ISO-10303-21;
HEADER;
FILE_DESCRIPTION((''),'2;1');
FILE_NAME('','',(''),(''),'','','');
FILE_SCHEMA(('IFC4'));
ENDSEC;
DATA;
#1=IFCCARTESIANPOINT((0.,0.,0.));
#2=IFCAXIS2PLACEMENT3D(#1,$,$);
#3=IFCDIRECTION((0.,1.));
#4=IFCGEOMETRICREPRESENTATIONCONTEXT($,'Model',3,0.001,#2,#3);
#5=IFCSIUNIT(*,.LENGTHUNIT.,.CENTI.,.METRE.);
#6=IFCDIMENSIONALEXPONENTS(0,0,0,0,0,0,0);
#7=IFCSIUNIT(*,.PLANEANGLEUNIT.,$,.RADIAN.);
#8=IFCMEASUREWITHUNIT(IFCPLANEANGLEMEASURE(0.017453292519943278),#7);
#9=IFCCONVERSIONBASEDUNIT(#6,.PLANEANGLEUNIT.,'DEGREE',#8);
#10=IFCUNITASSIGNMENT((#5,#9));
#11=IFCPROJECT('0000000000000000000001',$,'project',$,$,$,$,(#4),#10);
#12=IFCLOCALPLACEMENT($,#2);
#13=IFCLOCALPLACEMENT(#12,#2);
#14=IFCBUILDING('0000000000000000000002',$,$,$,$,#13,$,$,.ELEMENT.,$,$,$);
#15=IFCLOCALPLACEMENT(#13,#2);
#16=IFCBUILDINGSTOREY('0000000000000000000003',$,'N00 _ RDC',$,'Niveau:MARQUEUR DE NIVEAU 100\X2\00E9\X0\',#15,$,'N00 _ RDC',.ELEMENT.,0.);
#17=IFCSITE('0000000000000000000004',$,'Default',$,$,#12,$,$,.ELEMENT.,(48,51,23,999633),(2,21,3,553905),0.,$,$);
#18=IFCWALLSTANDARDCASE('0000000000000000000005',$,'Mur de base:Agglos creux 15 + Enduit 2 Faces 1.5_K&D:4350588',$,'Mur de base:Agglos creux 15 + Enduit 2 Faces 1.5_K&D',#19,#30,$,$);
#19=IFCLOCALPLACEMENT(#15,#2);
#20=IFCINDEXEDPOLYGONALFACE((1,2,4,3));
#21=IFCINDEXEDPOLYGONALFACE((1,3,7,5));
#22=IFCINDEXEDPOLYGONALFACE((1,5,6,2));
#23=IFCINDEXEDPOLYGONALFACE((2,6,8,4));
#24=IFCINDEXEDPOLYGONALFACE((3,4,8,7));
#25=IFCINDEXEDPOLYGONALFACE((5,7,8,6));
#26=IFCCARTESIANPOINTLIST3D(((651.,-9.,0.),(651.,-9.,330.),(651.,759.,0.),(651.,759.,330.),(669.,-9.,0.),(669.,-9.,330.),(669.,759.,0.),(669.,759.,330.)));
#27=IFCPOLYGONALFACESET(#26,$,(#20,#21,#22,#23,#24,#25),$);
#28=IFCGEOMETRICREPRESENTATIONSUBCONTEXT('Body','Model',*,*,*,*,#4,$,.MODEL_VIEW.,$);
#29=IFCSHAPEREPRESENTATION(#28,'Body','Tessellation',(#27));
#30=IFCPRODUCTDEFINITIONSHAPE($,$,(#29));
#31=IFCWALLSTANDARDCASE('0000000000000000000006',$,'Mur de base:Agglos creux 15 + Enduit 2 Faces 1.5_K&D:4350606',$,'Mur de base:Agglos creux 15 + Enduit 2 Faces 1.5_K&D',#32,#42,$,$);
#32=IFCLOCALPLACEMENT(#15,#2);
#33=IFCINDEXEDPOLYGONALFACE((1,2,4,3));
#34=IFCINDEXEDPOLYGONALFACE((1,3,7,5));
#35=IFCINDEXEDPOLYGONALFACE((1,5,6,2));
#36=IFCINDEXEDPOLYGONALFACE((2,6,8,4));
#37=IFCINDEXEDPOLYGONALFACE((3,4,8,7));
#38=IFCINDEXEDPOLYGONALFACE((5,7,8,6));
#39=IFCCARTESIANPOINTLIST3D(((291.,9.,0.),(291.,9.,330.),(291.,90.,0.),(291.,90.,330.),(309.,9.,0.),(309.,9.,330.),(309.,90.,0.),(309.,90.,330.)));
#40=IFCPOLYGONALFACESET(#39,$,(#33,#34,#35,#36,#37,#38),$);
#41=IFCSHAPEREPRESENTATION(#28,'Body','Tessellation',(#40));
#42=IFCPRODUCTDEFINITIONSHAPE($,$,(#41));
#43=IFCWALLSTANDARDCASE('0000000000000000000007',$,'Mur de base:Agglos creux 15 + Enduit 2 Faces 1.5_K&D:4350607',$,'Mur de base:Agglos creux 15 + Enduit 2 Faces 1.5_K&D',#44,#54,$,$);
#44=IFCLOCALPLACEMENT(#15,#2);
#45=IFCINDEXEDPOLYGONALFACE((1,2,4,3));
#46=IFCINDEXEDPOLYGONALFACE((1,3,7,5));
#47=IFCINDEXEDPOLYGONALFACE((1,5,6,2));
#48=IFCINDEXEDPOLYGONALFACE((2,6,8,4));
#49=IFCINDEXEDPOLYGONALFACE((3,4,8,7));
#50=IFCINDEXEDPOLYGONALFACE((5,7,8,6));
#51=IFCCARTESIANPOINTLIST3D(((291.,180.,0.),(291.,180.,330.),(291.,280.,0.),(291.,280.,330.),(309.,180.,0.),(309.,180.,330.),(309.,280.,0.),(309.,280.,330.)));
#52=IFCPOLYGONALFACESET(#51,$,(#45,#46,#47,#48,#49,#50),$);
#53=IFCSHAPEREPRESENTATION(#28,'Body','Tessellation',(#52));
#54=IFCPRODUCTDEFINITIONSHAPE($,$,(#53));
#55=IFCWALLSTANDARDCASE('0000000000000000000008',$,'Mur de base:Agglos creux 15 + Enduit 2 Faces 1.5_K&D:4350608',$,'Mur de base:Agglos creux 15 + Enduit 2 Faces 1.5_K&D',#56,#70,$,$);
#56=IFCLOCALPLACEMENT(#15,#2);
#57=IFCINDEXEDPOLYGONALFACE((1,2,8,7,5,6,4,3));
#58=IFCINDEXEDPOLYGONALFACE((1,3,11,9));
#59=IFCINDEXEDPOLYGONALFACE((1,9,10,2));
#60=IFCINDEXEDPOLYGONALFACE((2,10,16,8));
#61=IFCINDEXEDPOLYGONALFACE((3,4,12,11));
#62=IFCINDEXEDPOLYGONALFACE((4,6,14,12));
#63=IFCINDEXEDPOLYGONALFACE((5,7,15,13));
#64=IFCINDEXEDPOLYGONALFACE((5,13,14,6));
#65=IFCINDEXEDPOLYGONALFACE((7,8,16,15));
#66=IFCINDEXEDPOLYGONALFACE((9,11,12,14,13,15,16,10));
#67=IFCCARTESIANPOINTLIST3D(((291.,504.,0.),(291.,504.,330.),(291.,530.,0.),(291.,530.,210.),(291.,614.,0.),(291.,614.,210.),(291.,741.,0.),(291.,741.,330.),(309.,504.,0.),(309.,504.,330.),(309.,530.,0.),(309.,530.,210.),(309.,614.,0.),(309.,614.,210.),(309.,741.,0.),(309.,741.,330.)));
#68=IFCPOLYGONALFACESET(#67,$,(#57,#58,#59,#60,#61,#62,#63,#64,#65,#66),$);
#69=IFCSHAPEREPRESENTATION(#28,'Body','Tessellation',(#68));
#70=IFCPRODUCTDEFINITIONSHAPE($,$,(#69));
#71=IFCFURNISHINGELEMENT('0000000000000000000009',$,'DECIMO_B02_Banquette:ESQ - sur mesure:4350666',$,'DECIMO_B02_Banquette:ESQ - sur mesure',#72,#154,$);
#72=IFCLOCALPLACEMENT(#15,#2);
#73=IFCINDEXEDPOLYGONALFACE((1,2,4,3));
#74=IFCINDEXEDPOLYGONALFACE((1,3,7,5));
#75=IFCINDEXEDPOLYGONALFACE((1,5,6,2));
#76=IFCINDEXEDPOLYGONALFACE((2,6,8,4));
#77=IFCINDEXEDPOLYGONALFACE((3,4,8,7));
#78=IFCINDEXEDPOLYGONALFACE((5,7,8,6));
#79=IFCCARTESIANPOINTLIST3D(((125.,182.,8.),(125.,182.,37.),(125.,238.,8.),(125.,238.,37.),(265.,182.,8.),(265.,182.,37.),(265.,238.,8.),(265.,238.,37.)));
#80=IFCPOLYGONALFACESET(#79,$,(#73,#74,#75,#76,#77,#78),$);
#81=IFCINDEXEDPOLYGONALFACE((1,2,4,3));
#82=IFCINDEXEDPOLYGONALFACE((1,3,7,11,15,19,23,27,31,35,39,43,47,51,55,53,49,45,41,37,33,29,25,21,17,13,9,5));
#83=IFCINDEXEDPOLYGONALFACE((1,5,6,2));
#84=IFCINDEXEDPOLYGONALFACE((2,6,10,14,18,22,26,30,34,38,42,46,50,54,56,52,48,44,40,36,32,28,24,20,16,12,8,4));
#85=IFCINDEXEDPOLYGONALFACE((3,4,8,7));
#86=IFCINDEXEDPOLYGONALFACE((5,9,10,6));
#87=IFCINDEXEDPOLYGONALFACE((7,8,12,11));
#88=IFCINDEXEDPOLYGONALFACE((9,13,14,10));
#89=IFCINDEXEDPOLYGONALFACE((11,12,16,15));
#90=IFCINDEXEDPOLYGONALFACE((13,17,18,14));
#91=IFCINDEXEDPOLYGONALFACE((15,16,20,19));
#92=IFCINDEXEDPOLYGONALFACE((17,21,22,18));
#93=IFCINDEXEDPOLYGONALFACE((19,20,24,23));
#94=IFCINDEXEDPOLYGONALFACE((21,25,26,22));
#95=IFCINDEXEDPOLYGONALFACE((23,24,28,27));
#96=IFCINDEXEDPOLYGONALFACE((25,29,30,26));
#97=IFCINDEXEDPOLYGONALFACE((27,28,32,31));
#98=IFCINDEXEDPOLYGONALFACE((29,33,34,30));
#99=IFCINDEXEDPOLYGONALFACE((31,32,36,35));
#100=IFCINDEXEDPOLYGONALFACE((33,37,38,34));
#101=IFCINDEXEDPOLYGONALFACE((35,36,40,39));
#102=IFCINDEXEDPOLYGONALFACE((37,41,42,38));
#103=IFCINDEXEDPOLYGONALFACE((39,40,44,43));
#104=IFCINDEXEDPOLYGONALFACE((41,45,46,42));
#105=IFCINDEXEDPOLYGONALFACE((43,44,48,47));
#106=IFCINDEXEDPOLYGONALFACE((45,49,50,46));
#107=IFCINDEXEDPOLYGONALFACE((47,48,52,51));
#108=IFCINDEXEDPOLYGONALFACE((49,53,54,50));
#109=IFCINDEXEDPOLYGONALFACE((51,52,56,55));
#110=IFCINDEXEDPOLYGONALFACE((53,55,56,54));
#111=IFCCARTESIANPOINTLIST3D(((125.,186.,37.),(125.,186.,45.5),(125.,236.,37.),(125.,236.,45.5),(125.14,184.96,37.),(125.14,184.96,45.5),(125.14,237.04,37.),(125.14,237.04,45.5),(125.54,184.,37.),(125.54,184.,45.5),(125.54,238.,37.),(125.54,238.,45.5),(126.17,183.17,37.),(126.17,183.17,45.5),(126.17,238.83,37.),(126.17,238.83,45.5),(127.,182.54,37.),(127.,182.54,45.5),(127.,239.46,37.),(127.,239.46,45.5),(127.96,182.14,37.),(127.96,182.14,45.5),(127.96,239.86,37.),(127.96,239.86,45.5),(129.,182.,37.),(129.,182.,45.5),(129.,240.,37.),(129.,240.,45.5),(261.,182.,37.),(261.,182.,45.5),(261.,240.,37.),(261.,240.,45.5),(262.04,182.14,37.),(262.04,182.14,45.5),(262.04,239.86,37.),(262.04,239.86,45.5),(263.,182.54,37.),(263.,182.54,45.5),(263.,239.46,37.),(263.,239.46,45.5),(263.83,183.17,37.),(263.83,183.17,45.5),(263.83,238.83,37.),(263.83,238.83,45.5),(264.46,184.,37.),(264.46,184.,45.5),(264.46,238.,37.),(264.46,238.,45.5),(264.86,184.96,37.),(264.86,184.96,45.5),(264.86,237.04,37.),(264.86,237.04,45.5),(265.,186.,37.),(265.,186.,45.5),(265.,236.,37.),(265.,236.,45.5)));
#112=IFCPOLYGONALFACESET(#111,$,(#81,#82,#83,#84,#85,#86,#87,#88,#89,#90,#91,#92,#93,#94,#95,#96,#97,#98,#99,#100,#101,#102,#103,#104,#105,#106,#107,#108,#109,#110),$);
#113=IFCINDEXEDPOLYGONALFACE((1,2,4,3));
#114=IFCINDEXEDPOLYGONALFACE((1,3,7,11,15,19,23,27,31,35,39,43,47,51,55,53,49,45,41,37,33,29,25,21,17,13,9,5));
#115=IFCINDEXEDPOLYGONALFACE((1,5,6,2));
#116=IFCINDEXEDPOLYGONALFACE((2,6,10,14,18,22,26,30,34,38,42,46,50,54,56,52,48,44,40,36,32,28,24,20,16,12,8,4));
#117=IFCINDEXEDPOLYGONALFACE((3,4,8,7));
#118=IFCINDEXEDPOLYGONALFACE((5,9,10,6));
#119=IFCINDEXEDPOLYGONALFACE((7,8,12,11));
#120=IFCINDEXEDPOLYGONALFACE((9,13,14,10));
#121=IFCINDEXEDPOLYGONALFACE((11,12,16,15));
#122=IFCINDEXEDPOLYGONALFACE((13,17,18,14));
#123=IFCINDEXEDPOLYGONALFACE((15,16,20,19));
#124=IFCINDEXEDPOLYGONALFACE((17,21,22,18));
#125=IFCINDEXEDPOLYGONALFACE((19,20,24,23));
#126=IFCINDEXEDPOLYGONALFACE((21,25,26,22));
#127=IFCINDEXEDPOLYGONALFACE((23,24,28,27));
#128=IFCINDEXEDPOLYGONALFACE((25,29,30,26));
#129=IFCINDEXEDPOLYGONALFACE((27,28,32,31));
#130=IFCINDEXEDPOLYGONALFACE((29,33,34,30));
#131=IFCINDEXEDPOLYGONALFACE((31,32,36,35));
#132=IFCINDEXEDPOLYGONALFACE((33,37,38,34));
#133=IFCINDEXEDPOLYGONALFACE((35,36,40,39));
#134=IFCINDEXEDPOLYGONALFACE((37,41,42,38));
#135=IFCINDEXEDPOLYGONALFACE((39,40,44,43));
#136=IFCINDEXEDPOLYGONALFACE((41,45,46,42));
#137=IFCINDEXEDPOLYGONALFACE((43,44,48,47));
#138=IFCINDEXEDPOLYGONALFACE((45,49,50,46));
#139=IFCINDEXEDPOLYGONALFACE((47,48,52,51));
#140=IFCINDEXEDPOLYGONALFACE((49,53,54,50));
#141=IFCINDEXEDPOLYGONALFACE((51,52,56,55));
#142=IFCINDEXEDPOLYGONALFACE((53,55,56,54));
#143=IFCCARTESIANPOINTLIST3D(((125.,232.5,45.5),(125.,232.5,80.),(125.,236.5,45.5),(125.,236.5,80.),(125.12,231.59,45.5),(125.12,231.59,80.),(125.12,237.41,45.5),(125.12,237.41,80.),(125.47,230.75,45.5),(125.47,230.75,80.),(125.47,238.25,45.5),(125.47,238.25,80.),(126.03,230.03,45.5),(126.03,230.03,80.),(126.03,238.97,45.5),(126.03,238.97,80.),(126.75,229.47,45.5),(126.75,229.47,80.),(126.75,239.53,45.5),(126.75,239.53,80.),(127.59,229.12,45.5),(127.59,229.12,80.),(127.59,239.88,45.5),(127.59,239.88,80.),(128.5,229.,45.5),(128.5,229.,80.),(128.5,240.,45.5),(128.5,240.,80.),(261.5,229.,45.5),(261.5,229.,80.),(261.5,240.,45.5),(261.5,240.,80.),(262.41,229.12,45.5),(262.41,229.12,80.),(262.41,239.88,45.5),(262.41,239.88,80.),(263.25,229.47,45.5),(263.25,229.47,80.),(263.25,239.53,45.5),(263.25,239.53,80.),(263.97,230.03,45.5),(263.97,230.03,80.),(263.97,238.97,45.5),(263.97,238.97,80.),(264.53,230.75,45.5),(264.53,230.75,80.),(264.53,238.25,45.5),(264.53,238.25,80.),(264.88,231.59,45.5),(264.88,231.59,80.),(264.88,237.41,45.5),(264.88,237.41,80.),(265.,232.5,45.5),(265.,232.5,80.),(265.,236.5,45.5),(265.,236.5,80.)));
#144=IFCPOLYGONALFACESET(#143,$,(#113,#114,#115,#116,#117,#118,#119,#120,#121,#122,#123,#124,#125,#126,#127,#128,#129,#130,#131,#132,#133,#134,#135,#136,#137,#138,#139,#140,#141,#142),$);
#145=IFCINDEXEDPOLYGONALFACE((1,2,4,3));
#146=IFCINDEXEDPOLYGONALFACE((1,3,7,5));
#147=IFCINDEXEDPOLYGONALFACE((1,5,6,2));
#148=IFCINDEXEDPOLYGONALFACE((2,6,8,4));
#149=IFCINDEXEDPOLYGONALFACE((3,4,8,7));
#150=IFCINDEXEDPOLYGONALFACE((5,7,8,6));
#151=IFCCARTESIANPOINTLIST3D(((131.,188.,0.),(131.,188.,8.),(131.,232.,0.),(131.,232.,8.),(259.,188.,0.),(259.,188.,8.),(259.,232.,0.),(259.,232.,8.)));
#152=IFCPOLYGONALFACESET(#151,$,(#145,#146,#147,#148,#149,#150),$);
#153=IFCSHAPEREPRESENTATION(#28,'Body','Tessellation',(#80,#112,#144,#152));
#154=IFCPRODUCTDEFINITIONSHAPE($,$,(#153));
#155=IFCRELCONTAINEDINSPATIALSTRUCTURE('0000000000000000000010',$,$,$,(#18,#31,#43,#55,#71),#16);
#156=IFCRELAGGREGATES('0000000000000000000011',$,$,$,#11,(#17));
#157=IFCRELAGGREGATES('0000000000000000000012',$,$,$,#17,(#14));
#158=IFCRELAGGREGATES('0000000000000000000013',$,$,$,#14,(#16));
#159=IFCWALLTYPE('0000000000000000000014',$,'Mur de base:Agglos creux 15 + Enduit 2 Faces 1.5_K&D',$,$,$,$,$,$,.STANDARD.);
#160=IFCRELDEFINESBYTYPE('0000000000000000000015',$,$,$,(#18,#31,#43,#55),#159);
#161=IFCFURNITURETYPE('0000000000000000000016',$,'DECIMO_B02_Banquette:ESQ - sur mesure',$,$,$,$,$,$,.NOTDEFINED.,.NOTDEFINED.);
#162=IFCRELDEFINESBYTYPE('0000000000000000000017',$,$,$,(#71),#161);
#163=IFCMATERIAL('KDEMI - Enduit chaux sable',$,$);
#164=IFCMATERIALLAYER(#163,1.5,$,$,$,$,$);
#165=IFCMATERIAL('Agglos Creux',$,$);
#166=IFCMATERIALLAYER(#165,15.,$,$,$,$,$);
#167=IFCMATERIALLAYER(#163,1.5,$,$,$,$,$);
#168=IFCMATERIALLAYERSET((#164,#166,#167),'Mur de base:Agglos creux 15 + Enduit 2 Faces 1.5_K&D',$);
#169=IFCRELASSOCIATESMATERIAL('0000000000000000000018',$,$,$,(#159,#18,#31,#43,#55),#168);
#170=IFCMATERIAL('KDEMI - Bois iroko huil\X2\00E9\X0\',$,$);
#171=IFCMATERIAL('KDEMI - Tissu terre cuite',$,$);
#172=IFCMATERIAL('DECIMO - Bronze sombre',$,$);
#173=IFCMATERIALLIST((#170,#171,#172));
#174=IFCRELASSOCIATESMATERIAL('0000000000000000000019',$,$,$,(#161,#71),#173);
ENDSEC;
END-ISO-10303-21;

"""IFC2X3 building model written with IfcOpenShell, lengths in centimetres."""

from ifc_helpers import new_model, entity, si_unit, converted_unit, direction, frame, frame_2d, origin, origin_2d_with_axis, place, context, subcontext, project, spatial, polyline, circle_curve, parameter, trimmed, segment, composite_curve, rectangle, outline, extrude, source, transform, mapped, material, material_list, layer, layer_set, layer_usage, type_object, type_shapes, element, save


model = new_model("IFC2X3")

# Units and contexts
model_context = context("Model", 3, precision=0.001, world=origin(), true_north=direction((0.0, 1.0)))
body_context = subcontext(model_context, "Body", "Model", "MODEL_VIEW")
ifc_project = project(units=[si_unit("LENGTHUNIT", "METRE", prefix="CENTI"), converted_unit("PLANEANGLEUNIT", "DEGREE", entity("IfcPlaneAngleMeasure", 0.017453292519943278), si_unit("PLANEANGLEUNIT", "RADIAN"), dimensions=[0, 0, 0, 0, 0, 0, 0])], contexts=[model_context])

# Site, building, storey
site_placement = place(None, origin())
site = spatial("IfcSite", under=ifc_project, at=site_placement, Name="Default", CompositionType="ELEMENT", RefLatitude=(48, 51, 23, 999633), RefLongitude=(2, 21, 3, 553905), RefElevation=0.0)
building_placement = place(site_placement, origin())
building = spatial("IfcBuilding", under=site, at=building_placement, CompositionType="ELEMENT")
storey_placement = place(building_placement, origin())
storey = spatial("IfcBuildingStorey", under=building, at=storey_placement, Name="N00 _ RDC", ObjectType="Niveau:MARQUEUR DE NIVEAU 100é", LongName="N00 _ RDC", CompositionType="ELEMENT", Elevation=0.0)

# Walls
ifc_material_1 = material(Name="KDEMI - Enduit chaux sable")
ifc_layer_1 = layer(ifc_material_1, 1.5)
ifc_material_2 = material(Name="Agglos Creux")
ifc_layer_2 = layer(ifc_material_2, 15.0)
ifc_layer_3 = layer(ifc_material_1, 1.5)
ifc_layer_set = layer_set([ifc_layer_1, ifc_layer_2, ifc_layer_3], Name="Mur de base:Agglos creux 15 + Enduit 2 Faces 1.5_K&D")
ifc_layer_usage_1 = layer_usage(ifc_layer_set, "AXIS2", "NEGATIVE", 9.0)
wall_type = type_object("IfcWallType", Name="Mur de base:Agglos creux 15 + Enduit 2 Faces 1.5_K&D", PredefinedType="STANDARD", material=ifc_layer_set)
wall_1_placement = place(storey_placement, frame((660.0, -9.0, 0.0), z_axis=(0.0, 0.0, 1.0), x_axis=(0.0, 1.0, 0.0)))
element("IfcWallStandardCase", 1, at=wall_1_placement, inside=storey, type_object=wall_type, material=ifc_layer_usage_1, Name="Mur de base:Agglos creux 15 + Enduit 2 Faces 1.5_K&D:4350588", ObjectType="Mur de base:Agglos creux 15 + Enduit 2 Faces 1.5_K&D", context=body_context, shape_type="SweptSolid", body=[
    extrude(rectangle(XDim=768.0, YDim=18.0, at=frame_2d((384.0, 0.0), x_axis=(-1.0, 0.0))), origin(), (0.0, 0.0, 1.0), 330.0),
])
ifc_layer_usage_2 = layer_usage(ifc_layer_set, "AXIS2", "NEGATIVE", 9.0)
wall_2_placement = place(storey_placement, frame((300.0, 9.0, 0.0), z_axis=(0.0, 0.0, 1.0), x_axis=(0.0, 1.0, 0.0)))
element("IfcWallStandardCase", 2, at=wall_2_placement, inside=storey, type_object=wall_type, material=ifc_layer_usage_2, Name="Mur de base:Agglos creux 15 + Enduit 2 Faces 1.5_K&D:4350606", ObjectType="Mur de base:Agglos creux 15 + Enduit 2 Faces 1.5_K&D", context=body_context, shape_type="SweptSolid", body=[
    extrude(rectangle(XDim=81.0, YDim=18.0, at=frame_2d((40.5, 0.0), x_axis=(-1.0, 0.0))), origin(), (0.0, 0.0, 1.0), 330.0),
])
ifc_layer_usage_3 = layer_usage(ifc_layer_set, "AXIS2", "NEGATIVE", 9.0)
wall_3_placement = place(storey_placement, frame((300.0, 180.0, 0.0), z_axis=(0.0, 0.0, 1.0), x_axis=(0.0, 1.0, 0.0)))
element("IfcWallStandardCase", 3, at=wall_3_placement, inside=storey, type_object=wall_type, material=ifc_layer_usage_3, Name="Mur de base:Agglos creux 15 + Enduit 2 Faces 1.5_K&D:4350607", ObjectType="Mur de base:Agglos creux 15 + Enduit 2 Faces 1.5_K&D", context=body_context, shape_type="SweptSolid", body=[
    extrude(rectangle(XDim=100.0, YDim=18.0, at=frame_2d((50.0, 0.0), x_axis=(-1.0, 0.0))), origin(), (0.0, 0.0, 1.0), 330.0),
])

# Wall, opening
ifc_layer_usage_4 = layer_usage(ifc_layer_set, "AXIS2", "POSITIVE", -9.0)
wall_4_placement = place(storey_placement, frame((300.0, 504.0, 0.0), z_axis=(0.0, 0.0, 1.0), x_axis=(0.0, 1.0, 0.0)))
wall_4 = element("IfcWallStandardCase", 4, at=wall_4_placement, inside=storey, type_object=wall_type, material=ifc_layer_usage_4, Name="Mur de base:Agglos creux 15 + Enduit 2 Faces 1.5_K&D:4350608", ObjectType="Mur de base:Agglos creux 15 + Enduit 2 Faces 1.5_K&D", context=body_context, shape_type="SweptSolid", body=[
    extrude(rectangle(XDim=237.0, YDim=18.0, at=frame_2d((118.5, 0.0), x_axis=(1.0, 0.0))), origin(), (0.0, 0.0, 1.0), 330.0),
])
opening_placement = place(wall_4_placement, frame((-504.0, 300.0, 0.0), z_axis=(0.0, 0.0, 1.0), x_axis=(0.0, -1.0, 0.0)))
element("IfcOpeningElement", 5, at=opening_placement, inside=storey, cuts=wall_4, context=body_context, shape_type="SweptSolid", body=[
    extrude(rectangle(XDim=22.0, YDim=84.0, at=frame_2d((300.0, 572.0))), origin(), (0.0, 0.0, 1.0), 210.0),
])

# Furnishing element
ifc_material_3 = material(Name="DECIMO - Bronze sombre")
ifc_material_4 = material(Name="KDEMI - Bois iroko huilé")
ifc_material_5 = material(Name="KDEMI - Tissu terre cuite")
ifc_material_list_1 = material_list([ifc_material_4, ifc_material_5, ifc_material_3])
furniture_type_1 = type_object("IfcFurnitureType", Name="DECIMO_B02_Banquette:ESQ - sur mesure", AssemblyPlace="NOTDEFINED", material=ifc_material_list_1)
shared_shape_1 = source(origin(), body_context, "Body", "SweptSolid", [
    extrude(rectangle(XDim=140.0, YDim=56.0, at=origin_2d_with_axis()), frame((70.0, 28.0, 8.0)), (0.0, 0.0, 1.0), 29.0),
    extrude(outline(composite_curve([segment(polyline([(-66.0, -29.0), (66.0, -29.0)]), True, "CONTINUOUS"), segment(trimmed(circle_curve(frame_2d((66.0, -25.0), x_axis=(1.0, 0.0)), 4.0), [parameter(270.0)], [parameter(0.0)], True, "PARAMETER"), True, "CONTINUOUS"), segment(polyline([(70.0, -25.0), (70.0, 25.0)]), True, "CONTINUOUS"), segment(trimmed(circle_curve(frame_2d((66.0, 25.0), x_axis=(1.0, 0.0)), 4.0), [parameter(0.0)], [parameter(90.0)], True, "PARAMETER"), True, "CONTINUOUS"), segment(polyline([(66.0, 29.0), (-66.0, 29.0)]), True, "CONTINUOUS"), segment(trimmed(circle_curve(frame_2d((-66.0, 25.0), x_axis=(1.0, 0.0)), 4.0), [parameter(90.0)], [parameter(180.0)], True, "PARAMETER"), True, "CONTINUOUS"), segment(polyline([(-70.0, 25.0), (-70.0, -25.0)]), True, "CONTINUOUS"), segment(trimmed(circle_curve(frame_2d((-66.0, -25.0), x_axis=(1.0, 0.0)), 4.0), [parameter(180.0)], [parameter(270.0)], True, "PARAMETER"), True, "CONTINUOUS")], self_intersect=False)), frame((70.0, 29.0, 37.0)), (0.0, 0.0, 1.0), 8.5),
    extrude(outline(composite_curve([segment(polyline([(-66.5, -5.5), (66.5, -5.5)]), True, "CONTINUOUS"), segment(trimmed(circle_curve(frame_2d((66.5, -2.0), x_axis=(1.0, 0.0)), 3.5), [parameter(270.0)], [parameter(0.0)], True, "PARAMETER"), True, "CONTINUOUS"), segment(polyline([(70.0, -2.0), (70.0, 2.0)]), True, "CONTINUOUS"), segment(trimmed(circle_curve(frame_2d((66.5, 2.0), x_axis=(1.0, 0.0)), 3.5), [parameter(0.0)], [parameter(90.0)], True, "PARAMETER"), True, "CONTINUOUS"), segment(polyline([(66.5, 5.5), (-66.5, 5.5)]), True, "CONTINUOUS"), segment(trimmed(circle_curve(frame_2d((-66.5, 2.0), x_axis=(1.0, 0.0)), 3.5), [parameter(90.0)], [parameter(180.0)], True, "PARAMETER"), True, "CONTINUOUS"), segment(polyline([(-70.0, 2.0), (-70.0, -2.0)]), True, "CONTINUOUS"), segment(trimmed(circle_curve(frame_2d((-66.5, -2.0), x_axis=(1.0, 0.0)), 3.5), [parameter(180.0)], [parameter(270.0)], True, "PARAMETER"), True, "CONTINUOUS")], self_intersect=False)), frame((70.0, 52.5, 45.5)), (0.0, 0.0, 1.0), 34.5),
    extrude(rectangle(XDim=128.0, YDim=44.0, at=frame_2d((0.0, 0.0), x_axis=(1.0, 0.0))), frame((70.0, 28.0, 0.0)), (0.0, 0.0, 1.0), 8.0),
])
type_shapes(furniture_type_1, [shared_shape_1])
furnishing_1_placement = place(storey_placement, frame((125.0, 182.0, 0.0)))
element("IfcFurnishingElement", 6, at=furnishing_1_placement, inside=storey, type_object=furniture_type_1, material=ifc_material_list_1, Name="DECIMO_B02_Banquette:ESQ - sur mesure:4350666", ObjectType="DECIMO_B02_Banquette:ESQ - sur mesure", context=body_context, shape_type="MappedRepresentation", body=[
    mapped(shared_shape_1, transform((0.0, 0.0, 0.0), scale=1.0)),
])

save(model, "model.ifc")
